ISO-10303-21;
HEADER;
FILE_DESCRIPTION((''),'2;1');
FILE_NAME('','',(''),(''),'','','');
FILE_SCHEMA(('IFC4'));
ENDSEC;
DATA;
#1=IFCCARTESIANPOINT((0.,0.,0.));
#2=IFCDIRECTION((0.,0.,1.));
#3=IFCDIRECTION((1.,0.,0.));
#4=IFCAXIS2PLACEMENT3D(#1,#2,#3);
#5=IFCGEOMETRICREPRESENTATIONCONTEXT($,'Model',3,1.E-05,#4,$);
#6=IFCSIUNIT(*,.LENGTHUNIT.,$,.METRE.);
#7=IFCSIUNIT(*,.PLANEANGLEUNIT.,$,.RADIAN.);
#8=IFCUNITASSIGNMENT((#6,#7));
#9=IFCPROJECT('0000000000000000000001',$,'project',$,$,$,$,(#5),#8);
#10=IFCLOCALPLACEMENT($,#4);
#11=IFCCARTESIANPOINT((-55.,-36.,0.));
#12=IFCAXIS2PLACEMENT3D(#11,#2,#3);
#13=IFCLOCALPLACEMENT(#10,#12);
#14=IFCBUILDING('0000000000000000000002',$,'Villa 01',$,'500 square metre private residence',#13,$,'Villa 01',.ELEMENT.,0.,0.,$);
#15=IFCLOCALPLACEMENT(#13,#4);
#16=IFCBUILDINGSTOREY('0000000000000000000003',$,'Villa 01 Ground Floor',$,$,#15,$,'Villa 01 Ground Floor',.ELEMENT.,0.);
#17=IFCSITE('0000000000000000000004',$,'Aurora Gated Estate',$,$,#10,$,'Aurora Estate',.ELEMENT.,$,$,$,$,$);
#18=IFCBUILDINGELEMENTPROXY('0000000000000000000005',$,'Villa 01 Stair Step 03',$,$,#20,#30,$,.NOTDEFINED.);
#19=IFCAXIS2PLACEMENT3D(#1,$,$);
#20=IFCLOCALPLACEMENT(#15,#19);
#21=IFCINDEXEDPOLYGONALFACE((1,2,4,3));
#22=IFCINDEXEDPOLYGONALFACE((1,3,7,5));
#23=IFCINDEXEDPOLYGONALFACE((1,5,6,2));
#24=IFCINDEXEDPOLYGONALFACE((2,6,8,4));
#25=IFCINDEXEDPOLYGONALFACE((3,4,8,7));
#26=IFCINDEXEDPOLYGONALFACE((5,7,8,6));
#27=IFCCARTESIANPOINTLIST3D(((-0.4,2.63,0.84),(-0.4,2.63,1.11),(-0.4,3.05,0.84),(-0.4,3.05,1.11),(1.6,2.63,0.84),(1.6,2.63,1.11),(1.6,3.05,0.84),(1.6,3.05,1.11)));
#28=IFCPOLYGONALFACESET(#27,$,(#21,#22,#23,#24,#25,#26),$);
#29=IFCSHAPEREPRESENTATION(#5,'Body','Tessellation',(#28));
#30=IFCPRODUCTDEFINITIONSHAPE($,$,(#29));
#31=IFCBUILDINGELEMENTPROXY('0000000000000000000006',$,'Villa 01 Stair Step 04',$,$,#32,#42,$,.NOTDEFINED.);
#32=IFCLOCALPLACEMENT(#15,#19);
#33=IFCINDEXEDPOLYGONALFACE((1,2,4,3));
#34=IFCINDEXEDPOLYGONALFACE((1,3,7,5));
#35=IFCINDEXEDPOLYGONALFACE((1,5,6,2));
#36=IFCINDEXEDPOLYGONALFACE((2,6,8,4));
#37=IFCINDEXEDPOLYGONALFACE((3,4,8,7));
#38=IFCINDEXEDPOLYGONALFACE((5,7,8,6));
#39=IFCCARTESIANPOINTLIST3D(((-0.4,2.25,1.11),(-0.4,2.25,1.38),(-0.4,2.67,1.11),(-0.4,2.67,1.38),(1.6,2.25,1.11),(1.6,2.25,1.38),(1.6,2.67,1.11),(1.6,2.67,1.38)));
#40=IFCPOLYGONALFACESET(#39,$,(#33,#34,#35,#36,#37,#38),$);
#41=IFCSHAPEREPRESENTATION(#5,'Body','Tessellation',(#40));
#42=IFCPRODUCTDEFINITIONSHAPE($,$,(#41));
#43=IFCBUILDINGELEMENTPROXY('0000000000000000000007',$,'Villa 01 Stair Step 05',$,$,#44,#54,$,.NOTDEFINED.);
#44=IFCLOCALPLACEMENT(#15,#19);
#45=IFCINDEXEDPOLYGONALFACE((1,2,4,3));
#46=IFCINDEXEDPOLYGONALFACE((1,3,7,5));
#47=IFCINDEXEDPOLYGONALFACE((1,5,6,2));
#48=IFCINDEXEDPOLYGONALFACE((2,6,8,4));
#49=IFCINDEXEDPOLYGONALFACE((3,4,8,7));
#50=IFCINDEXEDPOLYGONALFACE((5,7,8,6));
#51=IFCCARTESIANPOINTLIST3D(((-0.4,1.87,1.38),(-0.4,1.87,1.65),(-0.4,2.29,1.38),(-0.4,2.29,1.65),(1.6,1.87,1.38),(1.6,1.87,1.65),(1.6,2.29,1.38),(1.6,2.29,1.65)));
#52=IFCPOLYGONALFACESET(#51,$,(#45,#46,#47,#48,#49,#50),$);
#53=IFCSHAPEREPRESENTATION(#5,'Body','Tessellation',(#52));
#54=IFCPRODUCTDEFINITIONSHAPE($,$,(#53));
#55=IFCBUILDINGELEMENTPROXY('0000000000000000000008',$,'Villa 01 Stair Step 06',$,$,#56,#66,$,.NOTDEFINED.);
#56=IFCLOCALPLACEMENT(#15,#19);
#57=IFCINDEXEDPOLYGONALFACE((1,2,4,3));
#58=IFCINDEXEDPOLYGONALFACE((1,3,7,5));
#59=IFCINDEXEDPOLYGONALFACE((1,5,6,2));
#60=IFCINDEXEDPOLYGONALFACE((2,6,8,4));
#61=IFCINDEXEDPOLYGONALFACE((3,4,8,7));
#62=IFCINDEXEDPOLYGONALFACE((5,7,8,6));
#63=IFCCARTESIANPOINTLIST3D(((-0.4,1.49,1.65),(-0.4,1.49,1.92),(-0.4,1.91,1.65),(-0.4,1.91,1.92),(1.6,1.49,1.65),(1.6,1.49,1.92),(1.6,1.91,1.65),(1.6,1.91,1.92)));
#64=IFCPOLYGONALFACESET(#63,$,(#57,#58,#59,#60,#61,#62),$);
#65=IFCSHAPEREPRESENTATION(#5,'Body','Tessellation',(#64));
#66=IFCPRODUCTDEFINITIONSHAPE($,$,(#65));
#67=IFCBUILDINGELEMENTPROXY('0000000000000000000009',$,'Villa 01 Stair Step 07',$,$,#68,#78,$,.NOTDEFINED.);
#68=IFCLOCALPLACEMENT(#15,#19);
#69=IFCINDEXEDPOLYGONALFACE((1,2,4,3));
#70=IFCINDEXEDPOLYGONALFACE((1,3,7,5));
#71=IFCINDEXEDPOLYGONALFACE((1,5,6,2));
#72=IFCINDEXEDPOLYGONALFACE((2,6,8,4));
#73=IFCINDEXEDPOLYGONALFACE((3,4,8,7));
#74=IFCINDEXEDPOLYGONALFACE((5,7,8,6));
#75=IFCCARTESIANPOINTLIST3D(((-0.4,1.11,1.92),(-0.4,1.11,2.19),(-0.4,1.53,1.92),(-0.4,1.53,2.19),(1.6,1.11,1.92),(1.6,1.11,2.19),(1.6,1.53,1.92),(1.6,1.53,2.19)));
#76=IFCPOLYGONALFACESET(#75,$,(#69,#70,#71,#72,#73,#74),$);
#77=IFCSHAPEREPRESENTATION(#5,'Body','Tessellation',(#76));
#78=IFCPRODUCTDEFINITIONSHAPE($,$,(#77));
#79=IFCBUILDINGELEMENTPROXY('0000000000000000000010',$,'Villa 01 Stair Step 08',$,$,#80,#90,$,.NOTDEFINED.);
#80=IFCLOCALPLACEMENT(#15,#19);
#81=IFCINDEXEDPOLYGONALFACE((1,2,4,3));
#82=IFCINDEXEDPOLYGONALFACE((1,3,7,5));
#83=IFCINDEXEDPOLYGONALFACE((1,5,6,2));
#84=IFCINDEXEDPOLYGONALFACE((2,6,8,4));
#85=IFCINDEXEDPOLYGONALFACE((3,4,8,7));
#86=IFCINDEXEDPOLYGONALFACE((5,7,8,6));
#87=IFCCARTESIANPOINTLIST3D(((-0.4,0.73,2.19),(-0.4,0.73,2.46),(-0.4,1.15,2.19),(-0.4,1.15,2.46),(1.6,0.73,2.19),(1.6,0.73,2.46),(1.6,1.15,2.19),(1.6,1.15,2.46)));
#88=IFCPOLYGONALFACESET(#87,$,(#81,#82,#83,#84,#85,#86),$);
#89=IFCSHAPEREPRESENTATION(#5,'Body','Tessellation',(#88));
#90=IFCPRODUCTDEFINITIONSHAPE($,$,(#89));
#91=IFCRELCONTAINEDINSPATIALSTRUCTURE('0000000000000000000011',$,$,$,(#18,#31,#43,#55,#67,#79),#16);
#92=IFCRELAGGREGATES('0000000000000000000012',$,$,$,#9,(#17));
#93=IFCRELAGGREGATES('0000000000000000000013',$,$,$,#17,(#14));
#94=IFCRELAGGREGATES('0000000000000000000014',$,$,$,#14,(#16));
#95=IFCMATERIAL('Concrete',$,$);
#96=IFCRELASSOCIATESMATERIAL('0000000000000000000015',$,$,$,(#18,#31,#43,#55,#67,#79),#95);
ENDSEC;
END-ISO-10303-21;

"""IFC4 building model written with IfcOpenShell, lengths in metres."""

from ifc_helpers import new_model, si_unit, frame, origin_with_axes, origin_2d_with_axis, place, context, project, spatial, rectangle, extrude, material, element, save


model = new_model("IFC4")

# Units and contexts
model_context = context("Model", 3, precision=1e-05, world=origin_with_axes())
ifc_project = project(units=[si_unit("LENGTHUNIT", "METRE"), si_unit("PLANEANGLEUNIT", "RADIAN")], contexts=[model_context])

# Site, building, storey
site_placement = place(None, origin_with_axes())
site = spatial("IfcSite", under=ifc_project, at=site_placement, Name="Aurora Gated Estate", LongName="Aurora Estate", CompositionType="ELEMENT")
building_placement = place(site_placement, frame((-55.0, -36.0, 0.0), z_axis=(0.0, 0.0, 1.0), x_axis=(1.0, 0.0, 0.0)))
building = spatial("IfcBuilding", under=site, at=building_placement, Name="Villa 01", ObjectType="500 square metre private residence", LongName="Villa 01", CompositionType="ELEMENT", ElevationOfRefHeight=0.0, ElevationOfTerrain=0.0)
storey_placement = place(building_placement, origin_with_axes())
storey = spatial("IfcBuildingStorey", under=building, at=storey_placement, Name="Villa 01 Ground Floor", LongName="Villa 01 Ground Floor", CompositionType="ELEMENT", Elevation=0.0)

# Building element proxies
ifc_material_1 = material(Name="Concrete")
for number, where, z_axis, x_axis, name in (
    (1, (0.6, 2.84, 0.84), (0.0, 0.0, 1.0), (1.0, 0.0, 0.0), "Villa 01 Stair Step 03"),
    (2, (0.6, 2.46, 1.11), (0.0, 0.0, 1.0), (1.0, 0.0, 0.0), "Villa 01 Stair Step 04"),
    (3, (0.6, 2.08, 1.38), (0.0, 0.0, 1.0), (1.0, 0.0, 0.0), "Villa 01 Stair Step 05"),
    (4, (0.6, 1.7, 1.65), (0.0, 0.0, 1.0), (1.0, 0.0, 0.0), "Villa 01 Stair Step 06"),
    (5, (0.6, 1.32, 1.92), (0.0, 0.0, 1.0), (1.0, 0.0, 0.0), "Villa 01 Stair Step 07"),
    (6, (0.6, 0.94, 2.19), (0.0, 0.0, 1.0), (1.0, 0.0, 0.0), "Villa 01 Stair Step 08"),
):
    element("IfcBuildingElementProxy", number, at=place(storey_placement, frame(where, z_axis=z_axis, x_axis=x_axis)), inside=storey, material=ifc_material_1, Name=name, PredefinedType="NOTDEFINED", context=model_context, shape_type="SweptSolid", body=[
        extrude(rectangle(XDim=2.0, YDim=0.42, at=origin_2d_with_axis()), origin_with_axes(), (0.0, 0.0, 1.0), 0.27),
    ])

save(model, "model.ifc")
